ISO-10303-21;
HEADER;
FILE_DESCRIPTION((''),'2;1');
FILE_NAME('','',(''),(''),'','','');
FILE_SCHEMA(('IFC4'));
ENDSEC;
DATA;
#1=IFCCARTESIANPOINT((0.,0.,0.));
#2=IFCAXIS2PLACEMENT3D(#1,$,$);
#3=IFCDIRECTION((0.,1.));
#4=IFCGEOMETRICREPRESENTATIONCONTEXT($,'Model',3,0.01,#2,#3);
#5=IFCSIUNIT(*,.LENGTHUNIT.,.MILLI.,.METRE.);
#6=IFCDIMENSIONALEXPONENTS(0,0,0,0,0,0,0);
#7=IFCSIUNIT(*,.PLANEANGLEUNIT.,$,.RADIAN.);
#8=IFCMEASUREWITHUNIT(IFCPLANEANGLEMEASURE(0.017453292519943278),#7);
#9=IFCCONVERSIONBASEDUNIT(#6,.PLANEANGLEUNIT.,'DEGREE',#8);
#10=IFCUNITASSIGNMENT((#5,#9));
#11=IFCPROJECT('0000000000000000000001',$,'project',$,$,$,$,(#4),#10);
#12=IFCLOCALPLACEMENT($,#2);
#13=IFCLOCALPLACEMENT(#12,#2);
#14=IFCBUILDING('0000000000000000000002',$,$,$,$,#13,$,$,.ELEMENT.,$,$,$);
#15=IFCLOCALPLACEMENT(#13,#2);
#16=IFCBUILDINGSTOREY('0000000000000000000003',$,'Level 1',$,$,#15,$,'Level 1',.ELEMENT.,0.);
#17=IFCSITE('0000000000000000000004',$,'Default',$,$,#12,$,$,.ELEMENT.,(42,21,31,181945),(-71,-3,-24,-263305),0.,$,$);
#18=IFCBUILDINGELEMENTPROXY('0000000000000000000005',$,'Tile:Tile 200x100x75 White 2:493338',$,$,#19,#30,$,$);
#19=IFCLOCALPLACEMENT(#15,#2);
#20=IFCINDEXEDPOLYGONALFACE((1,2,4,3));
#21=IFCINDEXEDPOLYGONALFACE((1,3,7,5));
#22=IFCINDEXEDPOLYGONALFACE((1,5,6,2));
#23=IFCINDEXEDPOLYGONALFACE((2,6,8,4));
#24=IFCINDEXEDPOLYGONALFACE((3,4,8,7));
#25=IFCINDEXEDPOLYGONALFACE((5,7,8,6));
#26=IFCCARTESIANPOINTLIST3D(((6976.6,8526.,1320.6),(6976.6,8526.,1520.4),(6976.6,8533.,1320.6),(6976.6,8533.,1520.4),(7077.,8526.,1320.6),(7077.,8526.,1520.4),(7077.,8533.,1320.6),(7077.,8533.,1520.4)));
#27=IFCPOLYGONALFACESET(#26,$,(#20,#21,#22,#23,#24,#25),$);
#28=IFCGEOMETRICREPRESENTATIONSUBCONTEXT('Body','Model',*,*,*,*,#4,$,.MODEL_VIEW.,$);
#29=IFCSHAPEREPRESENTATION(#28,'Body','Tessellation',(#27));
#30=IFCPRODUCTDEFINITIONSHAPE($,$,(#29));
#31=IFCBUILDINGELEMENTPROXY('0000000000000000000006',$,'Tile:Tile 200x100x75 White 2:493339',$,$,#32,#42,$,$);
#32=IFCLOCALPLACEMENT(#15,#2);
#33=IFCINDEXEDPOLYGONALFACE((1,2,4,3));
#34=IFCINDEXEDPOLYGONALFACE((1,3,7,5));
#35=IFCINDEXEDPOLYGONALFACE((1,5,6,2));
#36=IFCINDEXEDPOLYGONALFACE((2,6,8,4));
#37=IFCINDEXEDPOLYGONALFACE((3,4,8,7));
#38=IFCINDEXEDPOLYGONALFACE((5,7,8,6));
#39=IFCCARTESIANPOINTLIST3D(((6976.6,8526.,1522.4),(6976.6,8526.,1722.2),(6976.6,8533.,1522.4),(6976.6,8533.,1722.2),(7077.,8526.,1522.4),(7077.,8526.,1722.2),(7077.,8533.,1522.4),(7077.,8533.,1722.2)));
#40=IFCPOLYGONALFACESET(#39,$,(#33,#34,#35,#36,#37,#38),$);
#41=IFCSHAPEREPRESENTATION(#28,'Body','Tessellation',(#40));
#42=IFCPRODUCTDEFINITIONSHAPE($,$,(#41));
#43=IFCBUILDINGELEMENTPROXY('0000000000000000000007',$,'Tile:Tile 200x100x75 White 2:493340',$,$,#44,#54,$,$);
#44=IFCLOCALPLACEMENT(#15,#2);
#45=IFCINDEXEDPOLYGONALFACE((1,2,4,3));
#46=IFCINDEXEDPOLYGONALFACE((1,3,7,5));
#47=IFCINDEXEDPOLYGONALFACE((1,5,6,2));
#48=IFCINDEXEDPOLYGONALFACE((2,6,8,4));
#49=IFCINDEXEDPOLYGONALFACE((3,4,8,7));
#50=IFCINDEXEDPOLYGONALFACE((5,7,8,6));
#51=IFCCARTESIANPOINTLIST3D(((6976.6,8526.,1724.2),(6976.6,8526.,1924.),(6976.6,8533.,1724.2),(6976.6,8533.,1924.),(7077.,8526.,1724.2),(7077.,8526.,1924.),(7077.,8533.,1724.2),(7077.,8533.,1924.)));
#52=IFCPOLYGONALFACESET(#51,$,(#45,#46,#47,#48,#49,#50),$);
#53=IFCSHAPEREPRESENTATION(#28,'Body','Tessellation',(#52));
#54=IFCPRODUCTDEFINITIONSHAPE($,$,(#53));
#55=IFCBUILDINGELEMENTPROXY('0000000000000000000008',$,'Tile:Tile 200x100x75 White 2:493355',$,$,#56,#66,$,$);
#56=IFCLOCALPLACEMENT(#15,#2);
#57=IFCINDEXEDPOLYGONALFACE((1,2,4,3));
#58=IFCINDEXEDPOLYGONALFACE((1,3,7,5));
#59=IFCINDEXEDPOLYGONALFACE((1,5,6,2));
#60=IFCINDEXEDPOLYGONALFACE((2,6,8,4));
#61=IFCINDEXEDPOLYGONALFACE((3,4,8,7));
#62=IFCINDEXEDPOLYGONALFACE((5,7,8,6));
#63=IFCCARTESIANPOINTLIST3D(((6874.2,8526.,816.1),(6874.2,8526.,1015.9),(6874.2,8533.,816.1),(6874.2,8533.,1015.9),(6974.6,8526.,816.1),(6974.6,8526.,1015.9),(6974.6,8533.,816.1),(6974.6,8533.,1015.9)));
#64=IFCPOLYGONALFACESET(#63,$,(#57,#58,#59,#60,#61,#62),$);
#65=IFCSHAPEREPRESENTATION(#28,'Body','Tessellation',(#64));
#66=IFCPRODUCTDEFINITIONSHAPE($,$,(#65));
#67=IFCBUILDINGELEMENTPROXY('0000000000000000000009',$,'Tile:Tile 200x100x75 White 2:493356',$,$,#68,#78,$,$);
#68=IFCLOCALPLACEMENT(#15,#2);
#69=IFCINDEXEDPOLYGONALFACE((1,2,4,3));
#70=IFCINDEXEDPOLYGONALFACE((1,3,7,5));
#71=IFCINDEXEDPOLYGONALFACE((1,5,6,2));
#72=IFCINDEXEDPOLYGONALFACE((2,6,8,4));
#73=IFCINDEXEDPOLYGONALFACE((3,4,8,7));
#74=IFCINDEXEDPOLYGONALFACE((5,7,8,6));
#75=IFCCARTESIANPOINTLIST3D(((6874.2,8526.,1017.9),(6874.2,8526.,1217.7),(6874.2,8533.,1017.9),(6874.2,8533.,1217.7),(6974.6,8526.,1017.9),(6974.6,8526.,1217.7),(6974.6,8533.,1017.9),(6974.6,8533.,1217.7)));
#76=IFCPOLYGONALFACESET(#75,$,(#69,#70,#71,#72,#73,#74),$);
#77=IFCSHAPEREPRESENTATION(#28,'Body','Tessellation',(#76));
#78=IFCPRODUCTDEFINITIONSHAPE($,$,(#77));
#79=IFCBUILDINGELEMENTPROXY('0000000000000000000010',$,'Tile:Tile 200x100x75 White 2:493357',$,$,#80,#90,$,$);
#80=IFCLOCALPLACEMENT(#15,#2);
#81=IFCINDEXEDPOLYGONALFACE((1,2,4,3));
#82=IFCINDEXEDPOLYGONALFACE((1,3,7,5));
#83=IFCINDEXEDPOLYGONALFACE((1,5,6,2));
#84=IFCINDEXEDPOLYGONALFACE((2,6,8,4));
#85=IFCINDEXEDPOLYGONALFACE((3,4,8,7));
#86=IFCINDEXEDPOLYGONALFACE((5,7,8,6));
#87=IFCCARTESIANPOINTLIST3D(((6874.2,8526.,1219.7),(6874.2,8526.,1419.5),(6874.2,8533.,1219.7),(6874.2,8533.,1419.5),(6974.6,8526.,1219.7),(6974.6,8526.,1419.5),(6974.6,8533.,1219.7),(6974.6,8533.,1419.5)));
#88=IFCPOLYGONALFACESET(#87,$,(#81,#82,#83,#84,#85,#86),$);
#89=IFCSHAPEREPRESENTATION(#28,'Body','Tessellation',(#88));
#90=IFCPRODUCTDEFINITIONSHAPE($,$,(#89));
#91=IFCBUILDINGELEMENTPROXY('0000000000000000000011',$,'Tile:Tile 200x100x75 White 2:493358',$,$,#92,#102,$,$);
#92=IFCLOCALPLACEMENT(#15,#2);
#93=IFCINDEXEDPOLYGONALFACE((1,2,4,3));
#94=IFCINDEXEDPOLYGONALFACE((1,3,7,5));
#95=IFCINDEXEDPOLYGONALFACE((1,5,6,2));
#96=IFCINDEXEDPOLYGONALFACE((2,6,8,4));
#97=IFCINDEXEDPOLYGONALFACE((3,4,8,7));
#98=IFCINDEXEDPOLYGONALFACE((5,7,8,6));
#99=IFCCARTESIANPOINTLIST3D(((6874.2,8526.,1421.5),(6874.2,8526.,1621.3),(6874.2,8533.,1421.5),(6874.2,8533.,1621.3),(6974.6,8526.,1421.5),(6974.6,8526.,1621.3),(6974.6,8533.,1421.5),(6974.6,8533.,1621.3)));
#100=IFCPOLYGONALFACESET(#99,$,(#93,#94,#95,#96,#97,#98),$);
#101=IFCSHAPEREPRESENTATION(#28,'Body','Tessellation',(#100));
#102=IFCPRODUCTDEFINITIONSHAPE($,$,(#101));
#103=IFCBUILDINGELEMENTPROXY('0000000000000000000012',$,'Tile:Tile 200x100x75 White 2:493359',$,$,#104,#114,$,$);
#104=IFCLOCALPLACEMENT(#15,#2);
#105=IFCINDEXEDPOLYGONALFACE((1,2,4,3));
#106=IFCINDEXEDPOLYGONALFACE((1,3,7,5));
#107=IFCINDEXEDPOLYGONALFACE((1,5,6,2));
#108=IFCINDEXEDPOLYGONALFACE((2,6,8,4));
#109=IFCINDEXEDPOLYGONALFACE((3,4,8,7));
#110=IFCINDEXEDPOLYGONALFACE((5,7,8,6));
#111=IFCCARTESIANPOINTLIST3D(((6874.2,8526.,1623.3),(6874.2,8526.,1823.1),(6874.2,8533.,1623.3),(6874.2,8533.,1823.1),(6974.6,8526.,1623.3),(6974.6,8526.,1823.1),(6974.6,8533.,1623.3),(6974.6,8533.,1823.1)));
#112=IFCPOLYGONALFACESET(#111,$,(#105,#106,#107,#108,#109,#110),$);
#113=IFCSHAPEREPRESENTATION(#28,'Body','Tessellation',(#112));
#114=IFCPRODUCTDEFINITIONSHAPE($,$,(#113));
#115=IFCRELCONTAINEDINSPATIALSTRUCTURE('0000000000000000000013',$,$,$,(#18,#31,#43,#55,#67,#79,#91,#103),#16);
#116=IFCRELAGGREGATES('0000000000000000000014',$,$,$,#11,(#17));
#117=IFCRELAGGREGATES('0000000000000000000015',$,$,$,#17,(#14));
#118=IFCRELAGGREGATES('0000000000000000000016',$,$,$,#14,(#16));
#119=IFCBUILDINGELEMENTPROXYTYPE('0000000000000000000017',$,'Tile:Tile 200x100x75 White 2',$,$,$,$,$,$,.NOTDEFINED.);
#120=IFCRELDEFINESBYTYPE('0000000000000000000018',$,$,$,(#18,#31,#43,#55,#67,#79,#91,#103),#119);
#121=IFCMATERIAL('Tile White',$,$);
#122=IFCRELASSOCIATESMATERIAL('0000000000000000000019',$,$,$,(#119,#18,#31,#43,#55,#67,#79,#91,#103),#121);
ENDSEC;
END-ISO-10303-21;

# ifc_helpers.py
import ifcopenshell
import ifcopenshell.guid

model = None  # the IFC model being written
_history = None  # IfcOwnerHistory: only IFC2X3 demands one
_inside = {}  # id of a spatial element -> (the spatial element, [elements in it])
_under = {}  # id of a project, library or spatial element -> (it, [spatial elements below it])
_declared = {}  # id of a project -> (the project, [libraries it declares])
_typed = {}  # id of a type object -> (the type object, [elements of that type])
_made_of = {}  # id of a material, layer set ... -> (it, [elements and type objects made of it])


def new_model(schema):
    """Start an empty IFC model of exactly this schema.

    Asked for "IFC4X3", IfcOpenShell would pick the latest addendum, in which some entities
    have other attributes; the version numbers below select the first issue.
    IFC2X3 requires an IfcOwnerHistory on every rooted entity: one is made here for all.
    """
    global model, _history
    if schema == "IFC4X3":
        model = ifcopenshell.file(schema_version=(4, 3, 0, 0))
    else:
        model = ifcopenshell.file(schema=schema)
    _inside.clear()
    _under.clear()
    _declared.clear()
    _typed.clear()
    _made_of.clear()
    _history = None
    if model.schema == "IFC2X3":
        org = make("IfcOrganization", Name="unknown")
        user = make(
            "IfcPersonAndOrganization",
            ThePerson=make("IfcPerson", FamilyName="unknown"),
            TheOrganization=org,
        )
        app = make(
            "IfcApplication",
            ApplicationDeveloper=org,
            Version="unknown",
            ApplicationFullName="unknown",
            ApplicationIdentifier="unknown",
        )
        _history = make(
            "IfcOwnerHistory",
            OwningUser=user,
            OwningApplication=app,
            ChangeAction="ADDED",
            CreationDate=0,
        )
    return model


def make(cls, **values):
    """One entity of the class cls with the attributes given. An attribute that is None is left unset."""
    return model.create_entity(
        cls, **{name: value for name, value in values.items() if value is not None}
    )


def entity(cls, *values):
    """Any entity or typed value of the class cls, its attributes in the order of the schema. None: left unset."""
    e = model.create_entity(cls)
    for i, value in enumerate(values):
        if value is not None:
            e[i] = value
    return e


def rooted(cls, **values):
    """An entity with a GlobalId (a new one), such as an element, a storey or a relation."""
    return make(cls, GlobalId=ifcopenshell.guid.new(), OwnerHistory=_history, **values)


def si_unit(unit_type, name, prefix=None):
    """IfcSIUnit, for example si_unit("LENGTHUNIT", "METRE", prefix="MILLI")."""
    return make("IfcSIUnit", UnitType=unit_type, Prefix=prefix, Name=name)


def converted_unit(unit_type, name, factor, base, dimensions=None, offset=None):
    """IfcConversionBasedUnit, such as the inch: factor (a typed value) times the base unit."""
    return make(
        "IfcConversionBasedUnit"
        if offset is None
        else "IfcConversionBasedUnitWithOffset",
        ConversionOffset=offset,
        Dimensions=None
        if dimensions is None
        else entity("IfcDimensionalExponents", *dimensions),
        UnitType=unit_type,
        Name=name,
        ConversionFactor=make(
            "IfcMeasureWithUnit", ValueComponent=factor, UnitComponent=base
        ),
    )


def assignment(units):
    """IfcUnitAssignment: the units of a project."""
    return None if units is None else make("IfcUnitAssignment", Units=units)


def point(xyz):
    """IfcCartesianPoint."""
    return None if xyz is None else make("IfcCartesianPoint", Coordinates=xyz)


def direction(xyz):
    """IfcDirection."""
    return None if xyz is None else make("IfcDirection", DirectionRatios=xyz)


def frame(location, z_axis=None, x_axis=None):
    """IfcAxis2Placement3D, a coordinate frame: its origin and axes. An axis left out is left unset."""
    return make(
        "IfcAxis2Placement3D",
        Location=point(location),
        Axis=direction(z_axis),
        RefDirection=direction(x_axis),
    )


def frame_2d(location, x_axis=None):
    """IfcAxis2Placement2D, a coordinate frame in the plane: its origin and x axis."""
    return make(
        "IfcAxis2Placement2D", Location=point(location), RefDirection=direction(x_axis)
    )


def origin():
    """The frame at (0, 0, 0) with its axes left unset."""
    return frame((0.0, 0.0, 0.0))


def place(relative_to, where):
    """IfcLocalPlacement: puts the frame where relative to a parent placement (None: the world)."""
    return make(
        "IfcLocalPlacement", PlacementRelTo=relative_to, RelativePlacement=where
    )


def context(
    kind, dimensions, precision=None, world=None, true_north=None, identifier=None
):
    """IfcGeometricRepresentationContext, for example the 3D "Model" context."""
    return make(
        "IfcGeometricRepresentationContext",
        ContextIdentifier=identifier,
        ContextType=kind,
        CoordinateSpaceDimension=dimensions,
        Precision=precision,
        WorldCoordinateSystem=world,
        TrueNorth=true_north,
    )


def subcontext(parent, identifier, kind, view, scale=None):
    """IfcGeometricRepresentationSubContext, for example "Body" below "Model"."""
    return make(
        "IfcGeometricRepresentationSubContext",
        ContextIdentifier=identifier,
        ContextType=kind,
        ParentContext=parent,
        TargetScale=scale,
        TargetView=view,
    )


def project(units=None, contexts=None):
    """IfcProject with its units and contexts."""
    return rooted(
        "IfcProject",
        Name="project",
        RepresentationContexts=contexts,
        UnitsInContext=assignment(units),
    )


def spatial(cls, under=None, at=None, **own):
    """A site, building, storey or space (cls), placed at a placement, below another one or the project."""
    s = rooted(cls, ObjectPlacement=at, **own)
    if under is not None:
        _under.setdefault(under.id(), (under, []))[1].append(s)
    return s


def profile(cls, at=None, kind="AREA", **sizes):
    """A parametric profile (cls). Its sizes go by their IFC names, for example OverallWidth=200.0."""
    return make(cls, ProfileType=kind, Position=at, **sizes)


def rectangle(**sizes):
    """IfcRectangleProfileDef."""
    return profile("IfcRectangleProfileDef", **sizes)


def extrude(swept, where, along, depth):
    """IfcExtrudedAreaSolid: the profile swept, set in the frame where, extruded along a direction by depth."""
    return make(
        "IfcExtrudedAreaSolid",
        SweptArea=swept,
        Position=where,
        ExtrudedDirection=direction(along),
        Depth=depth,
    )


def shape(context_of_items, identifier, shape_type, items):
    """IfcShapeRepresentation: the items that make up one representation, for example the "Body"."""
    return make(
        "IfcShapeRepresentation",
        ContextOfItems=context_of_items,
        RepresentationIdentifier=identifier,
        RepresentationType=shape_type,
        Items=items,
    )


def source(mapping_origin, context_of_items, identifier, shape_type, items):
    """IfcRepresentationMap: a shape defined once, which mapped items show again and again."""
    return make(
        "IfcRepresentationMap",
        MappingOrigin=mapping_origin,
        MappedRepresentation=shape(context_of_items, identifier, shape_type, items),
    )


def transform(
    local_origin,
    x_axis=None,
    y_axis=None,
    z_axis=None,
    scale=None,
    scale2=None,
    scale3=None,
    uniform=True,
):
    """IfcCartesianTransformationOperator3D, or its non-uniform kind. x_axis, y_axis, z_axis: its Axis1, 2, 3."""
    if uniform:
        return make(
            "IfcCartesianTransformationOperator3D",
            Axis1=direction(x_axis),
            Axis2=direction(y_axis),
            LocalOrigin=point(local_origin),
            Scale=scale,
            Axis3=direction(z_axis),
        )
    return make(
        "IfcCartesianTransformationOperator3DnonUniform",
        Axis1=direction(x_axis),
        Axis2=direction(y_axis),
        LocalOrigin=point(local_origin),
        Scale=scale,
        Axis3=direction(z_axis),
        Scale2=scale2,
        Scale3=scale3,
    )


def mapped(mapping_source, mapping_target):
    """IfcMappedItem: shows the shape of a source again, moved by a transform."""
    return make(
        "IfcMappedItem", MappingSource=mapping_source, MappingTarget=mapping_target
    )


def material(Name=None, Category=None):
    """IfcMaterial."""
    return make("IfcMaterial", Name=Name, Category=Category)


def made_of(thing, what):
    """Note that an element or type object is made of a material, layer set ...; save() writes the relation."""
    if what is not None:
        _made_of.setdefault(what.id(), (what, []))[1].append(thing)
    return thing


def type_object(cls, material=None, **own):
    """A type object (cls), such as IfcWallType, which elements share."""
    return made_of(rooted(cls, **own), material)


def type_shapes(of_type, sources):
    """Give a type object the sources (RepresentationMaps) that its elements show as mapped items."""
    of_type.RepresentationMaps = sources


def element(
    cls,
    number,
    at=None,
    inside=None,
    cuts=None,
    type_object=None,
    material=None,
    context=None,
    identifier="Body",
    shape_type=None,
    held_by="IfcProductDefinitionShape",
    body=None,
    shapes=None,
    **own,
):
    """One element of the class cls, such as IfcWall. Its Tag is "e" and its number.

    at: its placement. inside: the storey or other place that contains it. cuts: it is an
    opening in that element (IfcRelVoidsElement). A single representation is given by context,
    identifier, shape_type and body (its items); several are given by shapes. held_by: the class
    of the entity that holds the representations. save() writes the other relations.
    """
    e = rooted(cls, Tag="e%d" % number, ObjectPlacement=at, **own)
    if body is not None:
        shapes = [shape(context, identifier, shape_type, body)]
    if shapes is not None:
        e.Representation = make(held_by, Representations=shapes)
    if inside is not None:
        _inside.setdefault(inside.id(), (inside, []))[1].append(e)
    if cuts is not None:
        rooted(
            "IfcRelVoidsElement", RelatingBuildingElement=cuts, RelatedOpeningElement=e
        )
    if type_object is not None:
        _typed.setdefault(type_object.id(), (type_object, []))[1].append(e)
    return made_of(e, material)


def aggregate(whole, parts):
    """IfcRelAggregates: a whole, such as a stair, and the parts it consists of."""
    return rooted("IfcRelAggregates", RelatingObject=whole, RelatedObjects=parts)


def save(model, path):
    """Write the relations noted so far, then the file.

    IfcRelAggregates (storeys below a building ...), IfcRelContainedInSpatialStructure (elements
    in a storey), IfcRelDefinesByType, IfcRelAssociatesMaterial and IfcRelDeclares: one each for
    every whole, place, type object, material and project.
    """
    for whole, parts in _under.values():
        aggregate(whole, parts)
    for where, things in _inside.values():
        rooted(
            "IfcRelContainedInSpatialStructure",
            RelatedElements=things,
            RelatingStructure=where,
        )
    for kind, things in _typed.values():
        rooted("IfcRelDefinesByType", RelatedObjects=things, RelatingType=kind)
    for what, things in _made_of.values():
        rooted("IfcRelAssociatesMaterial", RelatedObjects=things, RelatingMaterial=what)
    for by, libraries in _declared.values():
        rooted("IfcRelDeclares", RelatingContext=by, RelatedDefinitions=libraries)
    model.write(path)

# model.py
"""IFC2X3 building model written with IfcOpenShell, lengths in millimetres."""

from ifc_helpers import new_model, entity, si_unit, converted_unit, direction, frame, frame_2d, origin, place, context, subcontext, project, spatial, rectangle, extrude, source, transform, mapped, material, type_object, type_shapes, element, save


model = new_model("IFC2X3")

# Units and contexts
model_context = context("Model", 3, precision=0.01, world=origin(), true_north=direction((0.0, 1.0)))
body_context = subcontext(model_context, "Body", "Model", "MODEL_VIEW")
ifc_project = project(units=[si_unit("LENGTHUNIT", "METRE", prefix="MILLI"), converted_unit("PLANEANGLEUNIT", "DEGREE", entity("IfcPlaneAngleMeasure", 0.017453292519943278), si_unit("PLANEANGLEUNIT", "RADIAN"), dimensions=[0, 0, 0, 0, 0, 0, 0])], contexts=[model_context])

# Site, building, storey
site_placement = place(None, origin())
site = spatial("IfcSite", under=ifc_project, at=site_placement, Name="Default", CompositionType="ELEMENT", RefLatitude=(42, 21, 31, 181945), RefLongitude=(-71, -3, -24, -263305), RefElevation=0.0)
building_placement = place(site_placement, origin())
building = spatial("IfcBuilding", under=site, at=building_placement, CompositionType="ELEMENT")
storey_placement = place(building_placement, origin())
storey = spatial("IfcBuildingStorey", under=building, at=storey_placement, Name="Level 1", LongName="Level 1", CompositionType="ELEMENT", Elevation=0.0)

# Building element proxies
ifc_material = material(Name="Tile White")
building_element_proxy_type_1 = type_object("IfcBuildingElementProxyType", Name="Tile:Tile 200x100x75 White 2", PredefinedType="NOTDEFINED", material=ifc_material)
shared_shape_1 = source(origin(), body_context, "Body", "SweptSolid", [
    extrude(rectangle(XDim=199.8, YDim=100.4, at=frame_2d((0.0, 0.0), x_axis=(1.0, 0.0))), frame((-50.2, -99.9, 0.0), z_axis=(0.0, 0.0, 1.0), x_axis=(0.0, -1.0, 0.0)), (0.0, 0.0, 1.0), 7.0),
])
type_shapes(building_element_proxy_type_1, [shared_shape_1])
for number, where, z_axis, x_axis, name in (
    (1, (7077.0, 8533.0, 1520.4), (0.0, -1.0, 0.0), (1.0, 0.0, 0.0), "Tile:Tile 200x100x75 White 2:493338"),
    (2, (7077.0, 8533.0, 1722.2), (0.0, -1.0, 0.0), (1.0, 0.0, 0.0), "Tile:Tile 200x100x75 White 2:493339"),
    (3, (7077.0, 8533.0, 1924.0), (0.0, -1.0, 0.0), (1.0, 0.0, 0.0), "Tile:Tile 200x100x75 White 2:493340"),
    (4, (6974.6, 8533.0, 1015.9), (0.0, -1.0, 0.0), (1.0, 0.0, 0.0), "Tile:Tile 200x100x75 White 2:493355"),
    (5, (6974.6, 8533.0, 1217.7), (0.0, -1.0, 0.0), (1.0, 0.0, 0.0), "Tile:Tile 200x100x75 White 2:493356"),
    (6, (6974.6, 8533.0, 1419.5), (0.0, -1.0, 0.0), (1.0, 0.0, 0.0), "Tile:Tile 200x100x75 White 2:493357"),
    (7, (6974.6, 8533.0, 1621.3), (0.0, -1.0, 0.0), (1.0, 0.0, 0.0), "Tile:Tile 200x100x75 White 2:493358"),
    (8, (6974.6, 8533.0, 1823.1), (0.0, -1.0, 0.0), (1.0, 0.0, 0.0), "Tile:Tile 200x100x75 White 2:493359"),
):
    element("IfcBuildingElementProxy", number, at=place(storey_placement, frame(where, z_axis=z_axis, x_axis=x_axis)), inside=storey, type_object=building_element_proxy_type_1, material=ifc_material, Name=name, context=body_context, shape_type="MappedRepresentation", body=[
        mapped(shared_shape_1, transform((0.0, 0.0, 0.0), scale=1.0)),
    ])

save(model, "model.ifc")
